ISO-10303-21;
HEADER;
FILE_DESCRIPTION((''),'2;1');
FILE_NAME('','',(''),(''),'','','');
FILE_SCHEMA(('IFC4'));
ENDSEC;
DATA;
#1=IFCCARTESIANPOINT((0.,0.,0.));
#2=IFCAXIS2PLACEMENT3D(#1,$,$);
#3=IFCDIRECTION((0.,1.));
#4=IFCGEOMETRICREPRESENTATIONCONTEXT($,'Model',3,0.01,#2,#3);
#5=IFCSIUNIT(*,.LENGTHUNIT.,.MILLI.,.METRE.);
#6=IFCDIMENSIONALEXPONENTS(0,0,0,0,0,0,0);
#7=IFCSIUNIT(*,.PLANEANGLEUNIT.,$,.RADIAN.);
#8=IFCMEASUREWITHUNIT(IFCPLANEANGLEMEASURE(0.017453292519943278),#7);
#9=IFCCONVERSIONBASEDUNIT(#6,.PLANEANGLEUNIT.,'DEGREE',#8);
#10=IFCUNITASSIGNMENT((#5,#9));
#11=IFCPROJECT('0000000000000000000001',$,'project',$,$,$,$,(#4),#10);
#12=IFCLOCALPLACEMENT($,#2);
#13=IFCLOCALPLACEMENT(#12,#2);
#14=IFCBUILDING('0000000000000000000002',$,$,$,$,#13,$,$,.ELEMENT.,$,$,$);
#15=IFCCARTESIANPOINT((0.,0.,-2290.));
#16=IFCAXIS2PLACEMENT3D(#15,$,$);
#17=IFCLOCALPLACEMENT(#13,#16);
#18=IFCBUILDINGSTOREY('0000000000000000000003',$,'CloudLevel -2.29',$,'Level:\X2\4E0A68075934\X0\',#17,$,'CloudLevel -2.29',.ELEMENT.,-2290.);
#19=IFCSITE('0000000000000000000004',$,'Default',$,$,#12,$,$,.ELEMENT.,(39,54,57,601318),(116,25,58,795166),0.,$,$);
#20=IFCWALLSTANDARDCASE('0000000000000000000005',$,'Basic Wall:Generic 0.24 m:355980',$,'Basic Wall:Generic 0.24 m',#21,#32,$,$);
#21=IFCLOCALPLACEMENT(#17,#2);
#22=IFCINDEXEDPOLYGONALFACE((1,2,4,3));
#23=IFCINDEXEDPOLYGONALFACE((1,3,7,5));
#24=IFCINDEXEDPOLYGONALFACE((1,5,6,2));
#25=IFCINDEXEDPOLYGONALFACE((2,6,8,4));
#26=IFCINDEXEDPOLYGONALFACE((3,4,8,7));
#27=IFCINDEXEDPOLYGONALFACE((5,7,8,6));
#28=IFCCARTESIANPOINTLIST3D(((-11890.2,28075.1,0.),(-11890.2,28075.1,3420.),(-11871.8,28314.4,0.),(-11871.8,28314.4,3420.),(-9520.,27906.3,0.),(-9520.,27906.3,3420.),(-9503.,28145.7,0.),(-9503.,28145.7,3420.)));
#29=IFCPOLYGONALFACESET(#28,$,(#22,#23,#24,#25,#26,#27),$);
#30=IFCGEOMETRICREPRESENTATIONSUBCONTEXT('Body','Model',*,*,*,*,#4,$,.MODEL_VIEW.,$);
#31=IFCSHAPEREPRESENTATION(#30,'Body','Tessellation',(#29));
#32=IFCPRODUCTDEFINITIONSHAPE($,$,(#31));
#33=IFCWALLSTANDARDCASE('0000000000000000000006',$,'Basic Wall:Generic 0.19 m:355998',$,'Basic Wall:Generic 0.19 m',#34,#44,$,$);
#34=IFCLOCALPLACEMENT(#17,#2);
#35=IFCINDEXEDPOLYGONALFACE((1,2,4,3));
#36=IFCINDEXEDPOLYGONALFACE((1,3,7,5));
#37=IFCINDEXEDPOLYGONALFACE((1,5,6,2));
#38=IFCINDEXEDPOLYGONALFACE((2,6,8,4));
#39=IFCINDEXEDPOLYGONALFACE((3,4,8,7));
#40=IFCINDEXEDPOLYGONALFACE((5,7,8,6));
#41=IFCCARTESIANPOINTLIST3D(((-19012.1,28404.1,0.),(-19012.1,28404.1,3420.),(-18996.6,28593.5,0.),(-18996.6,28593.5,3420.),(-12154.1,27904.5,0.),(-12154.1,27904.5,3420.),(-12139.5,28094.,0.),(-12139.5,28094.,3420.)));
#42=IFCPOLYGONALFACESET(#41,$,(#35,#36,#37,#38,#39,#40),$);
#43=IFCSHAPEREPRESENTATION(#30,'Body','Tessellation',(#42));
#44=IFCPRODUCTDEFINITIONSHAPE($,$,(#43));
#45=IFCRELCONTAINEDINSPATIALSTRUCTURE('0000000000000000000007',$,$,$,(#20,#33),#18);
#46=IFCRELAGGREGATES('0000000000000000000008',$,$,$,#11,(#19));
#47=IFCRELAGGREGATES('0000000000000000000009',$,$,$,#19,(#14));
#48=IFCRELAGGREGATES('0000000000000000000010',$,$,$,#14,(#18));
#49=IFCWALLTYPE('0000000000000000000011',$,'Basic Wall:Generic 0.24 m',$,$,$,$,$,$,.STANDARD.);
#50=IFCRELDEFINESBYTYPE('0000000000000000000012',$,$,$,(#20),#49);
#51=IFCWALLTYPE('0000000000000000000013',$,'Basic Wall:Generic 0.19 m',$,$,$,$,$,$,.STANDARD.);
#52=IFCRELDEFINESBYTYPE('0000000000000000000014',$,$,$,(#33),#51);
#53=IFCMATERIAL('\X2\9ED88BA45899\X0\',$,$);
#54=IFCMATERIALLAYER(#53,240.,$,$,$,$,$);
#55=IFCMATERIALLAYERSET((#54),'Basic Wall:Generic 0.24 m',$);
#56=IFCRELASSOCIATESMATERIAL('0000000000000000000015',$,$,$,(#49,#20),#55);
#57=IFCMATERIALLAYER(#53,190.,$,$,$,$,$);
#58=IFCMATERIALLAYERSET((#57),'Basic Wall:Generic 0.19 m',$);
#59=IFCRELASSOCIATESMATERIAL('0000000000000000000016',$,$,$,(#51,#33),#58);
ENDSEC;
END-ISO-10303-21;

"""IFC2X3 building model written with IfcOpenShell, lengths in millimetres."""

from ifc_helpers import new_model, entity, si_unit, converted_unit, direction, frame, origin, place, context, subcontext, project, spatial, polyline, outline, extrude, material, layer, layer_set, layer_usage, type_object, element, save


model = new_model("IFC2X3")

# Units and contexts
model_context = context("Model", 3, precision=0.01, world=origin(), true_north=direction((0.0, 1.0)))
body_context = subcontext(model_context, "Body", "Model", "MODEL_VIEW")
ifc_project = project(units=[si_unit("LENGTHUNIT", "METRE", prefix="MILLI"), converted_unit("PLANEANGLEUNIT", "DEGREE", entity("IfcPlaneAngleMeasure", 0.017453292519943278), si_unit("PLANEANGLEUNIT", "RADIAN"), dimensions=[0, 0, 0, 0, 0, 0, 0])], contexts=[model_context])

# Site, building, storey
site_placement = place(None, origin())
site = spatial("IfcSite", under=ifc_project, at=site_placement, Name="Default", CompositionType="ELEMENT", RefLatitude=(39, 54, 57, 601318), RefLongitude=(116, 25, 58, 795166), RefElevation=0.0)
building_placement = place(site_placement, origin())
building = spatial("IfcBuilding", under=site, at=building_placement, CompositionType="ELEMENT")
storey_placement = place(building_placement, frame((0.0, 0.0, -2290.0)))
storey = spatial("IfcBuildingStorey", under=building, at=storey_placement, Name="CloudLevel -2.29", ObjectType="Level:上标头", LongName="CloudLevel -2.29", CompositionType="ELEMENT", Elevation=-2290.0)

# Shared definitions
ifc_material_1 = material(Name="默认墙")

# Walls
ifc_layer_1 = layer(ifc_material_1, 240.0)
ifc_layer_set_1 = layer_set([ifc_layer_1], Name="Basic Wall:Generic 0.24 m")
ifc_layer_usage_1 = layer_usage(ifc_layer_set_1, "AXIS2", "NEGATIVE", 120.0)
wall_type_1 = type_object("IfcWallType", Name="Basic Wall:Generic 0.24 m", PredefinedType="STANDARD", material=ifc_layer_set_1)
wall_1_placement = place(storey_placement, frame((-9511.5, 28026.0, 0.0), z_axis=(0.0, 0.0, 1.0), x_axis=(-0.997475, 0.071022, 0.0)))
element("IfcWallStandardCase", 1, at=wall_1_placement, inside=storey, type_object=wall_type_1, material=ifc_layer_usage_1, Name="Basic Wall:Generic 0.24 m:355980", ObjectType="Basic Wall:Generic 0.24 m", context=body_context, shape_type="SweptSolid", body=[
    extrude(outline(polyline([(2374.8, -120.0), (2376.2, 120.0), (0.0, 120.0), (0.0, -120.0), (2374.8, -120.0)])), origin(), (0.0, 0.0, 1.0), 3420.0),
])
ifc_layer_2 = layer(ifc_material_1, 190.0)
ifc_layer_set_2 = layer_set([ifc_layer_2], Name="Basic Wall:Generic 0.19 m")
ifc_layer_usage_2 = layer_usage(ifc_layer_set_2, "AXIS2", "NEGATIVE", 95.0)
wall_type_2 = type_object("IfcWallType", Name="Basic Wall:Generic 0.19 m", PredefinedType="STANDARD", material=ifc_layer_set_2)
wall_2_placement = place(storey_placement, frame((-19005.2, 28498.8, 0.0), z_axis=(0.0, 0.0, 1.0), x_axis=(0.997358, -0.072649, 0.0)))
element("IfcWallStandardCase", 2, at=wall_2_placement, inside=storey, type_object=wall_type_2, material=ifc_layer_usage_2, Name="Basic Wall:Generic 0.19 m:355998", ObjectType="Basic Wall:Generic 0.19 m", context=body_context, shape_type="SweptSolid", body=[
    extrude(outline(polyline([(6876.2, -95.0), (6877.0, 95.0), (1.7, 95.0), (0.0, -95.0), (6876.2, -95.0)])), origin(), (0.0, 0.0, 1.0), 3420.0),
])

save(model, "model.ifc")
